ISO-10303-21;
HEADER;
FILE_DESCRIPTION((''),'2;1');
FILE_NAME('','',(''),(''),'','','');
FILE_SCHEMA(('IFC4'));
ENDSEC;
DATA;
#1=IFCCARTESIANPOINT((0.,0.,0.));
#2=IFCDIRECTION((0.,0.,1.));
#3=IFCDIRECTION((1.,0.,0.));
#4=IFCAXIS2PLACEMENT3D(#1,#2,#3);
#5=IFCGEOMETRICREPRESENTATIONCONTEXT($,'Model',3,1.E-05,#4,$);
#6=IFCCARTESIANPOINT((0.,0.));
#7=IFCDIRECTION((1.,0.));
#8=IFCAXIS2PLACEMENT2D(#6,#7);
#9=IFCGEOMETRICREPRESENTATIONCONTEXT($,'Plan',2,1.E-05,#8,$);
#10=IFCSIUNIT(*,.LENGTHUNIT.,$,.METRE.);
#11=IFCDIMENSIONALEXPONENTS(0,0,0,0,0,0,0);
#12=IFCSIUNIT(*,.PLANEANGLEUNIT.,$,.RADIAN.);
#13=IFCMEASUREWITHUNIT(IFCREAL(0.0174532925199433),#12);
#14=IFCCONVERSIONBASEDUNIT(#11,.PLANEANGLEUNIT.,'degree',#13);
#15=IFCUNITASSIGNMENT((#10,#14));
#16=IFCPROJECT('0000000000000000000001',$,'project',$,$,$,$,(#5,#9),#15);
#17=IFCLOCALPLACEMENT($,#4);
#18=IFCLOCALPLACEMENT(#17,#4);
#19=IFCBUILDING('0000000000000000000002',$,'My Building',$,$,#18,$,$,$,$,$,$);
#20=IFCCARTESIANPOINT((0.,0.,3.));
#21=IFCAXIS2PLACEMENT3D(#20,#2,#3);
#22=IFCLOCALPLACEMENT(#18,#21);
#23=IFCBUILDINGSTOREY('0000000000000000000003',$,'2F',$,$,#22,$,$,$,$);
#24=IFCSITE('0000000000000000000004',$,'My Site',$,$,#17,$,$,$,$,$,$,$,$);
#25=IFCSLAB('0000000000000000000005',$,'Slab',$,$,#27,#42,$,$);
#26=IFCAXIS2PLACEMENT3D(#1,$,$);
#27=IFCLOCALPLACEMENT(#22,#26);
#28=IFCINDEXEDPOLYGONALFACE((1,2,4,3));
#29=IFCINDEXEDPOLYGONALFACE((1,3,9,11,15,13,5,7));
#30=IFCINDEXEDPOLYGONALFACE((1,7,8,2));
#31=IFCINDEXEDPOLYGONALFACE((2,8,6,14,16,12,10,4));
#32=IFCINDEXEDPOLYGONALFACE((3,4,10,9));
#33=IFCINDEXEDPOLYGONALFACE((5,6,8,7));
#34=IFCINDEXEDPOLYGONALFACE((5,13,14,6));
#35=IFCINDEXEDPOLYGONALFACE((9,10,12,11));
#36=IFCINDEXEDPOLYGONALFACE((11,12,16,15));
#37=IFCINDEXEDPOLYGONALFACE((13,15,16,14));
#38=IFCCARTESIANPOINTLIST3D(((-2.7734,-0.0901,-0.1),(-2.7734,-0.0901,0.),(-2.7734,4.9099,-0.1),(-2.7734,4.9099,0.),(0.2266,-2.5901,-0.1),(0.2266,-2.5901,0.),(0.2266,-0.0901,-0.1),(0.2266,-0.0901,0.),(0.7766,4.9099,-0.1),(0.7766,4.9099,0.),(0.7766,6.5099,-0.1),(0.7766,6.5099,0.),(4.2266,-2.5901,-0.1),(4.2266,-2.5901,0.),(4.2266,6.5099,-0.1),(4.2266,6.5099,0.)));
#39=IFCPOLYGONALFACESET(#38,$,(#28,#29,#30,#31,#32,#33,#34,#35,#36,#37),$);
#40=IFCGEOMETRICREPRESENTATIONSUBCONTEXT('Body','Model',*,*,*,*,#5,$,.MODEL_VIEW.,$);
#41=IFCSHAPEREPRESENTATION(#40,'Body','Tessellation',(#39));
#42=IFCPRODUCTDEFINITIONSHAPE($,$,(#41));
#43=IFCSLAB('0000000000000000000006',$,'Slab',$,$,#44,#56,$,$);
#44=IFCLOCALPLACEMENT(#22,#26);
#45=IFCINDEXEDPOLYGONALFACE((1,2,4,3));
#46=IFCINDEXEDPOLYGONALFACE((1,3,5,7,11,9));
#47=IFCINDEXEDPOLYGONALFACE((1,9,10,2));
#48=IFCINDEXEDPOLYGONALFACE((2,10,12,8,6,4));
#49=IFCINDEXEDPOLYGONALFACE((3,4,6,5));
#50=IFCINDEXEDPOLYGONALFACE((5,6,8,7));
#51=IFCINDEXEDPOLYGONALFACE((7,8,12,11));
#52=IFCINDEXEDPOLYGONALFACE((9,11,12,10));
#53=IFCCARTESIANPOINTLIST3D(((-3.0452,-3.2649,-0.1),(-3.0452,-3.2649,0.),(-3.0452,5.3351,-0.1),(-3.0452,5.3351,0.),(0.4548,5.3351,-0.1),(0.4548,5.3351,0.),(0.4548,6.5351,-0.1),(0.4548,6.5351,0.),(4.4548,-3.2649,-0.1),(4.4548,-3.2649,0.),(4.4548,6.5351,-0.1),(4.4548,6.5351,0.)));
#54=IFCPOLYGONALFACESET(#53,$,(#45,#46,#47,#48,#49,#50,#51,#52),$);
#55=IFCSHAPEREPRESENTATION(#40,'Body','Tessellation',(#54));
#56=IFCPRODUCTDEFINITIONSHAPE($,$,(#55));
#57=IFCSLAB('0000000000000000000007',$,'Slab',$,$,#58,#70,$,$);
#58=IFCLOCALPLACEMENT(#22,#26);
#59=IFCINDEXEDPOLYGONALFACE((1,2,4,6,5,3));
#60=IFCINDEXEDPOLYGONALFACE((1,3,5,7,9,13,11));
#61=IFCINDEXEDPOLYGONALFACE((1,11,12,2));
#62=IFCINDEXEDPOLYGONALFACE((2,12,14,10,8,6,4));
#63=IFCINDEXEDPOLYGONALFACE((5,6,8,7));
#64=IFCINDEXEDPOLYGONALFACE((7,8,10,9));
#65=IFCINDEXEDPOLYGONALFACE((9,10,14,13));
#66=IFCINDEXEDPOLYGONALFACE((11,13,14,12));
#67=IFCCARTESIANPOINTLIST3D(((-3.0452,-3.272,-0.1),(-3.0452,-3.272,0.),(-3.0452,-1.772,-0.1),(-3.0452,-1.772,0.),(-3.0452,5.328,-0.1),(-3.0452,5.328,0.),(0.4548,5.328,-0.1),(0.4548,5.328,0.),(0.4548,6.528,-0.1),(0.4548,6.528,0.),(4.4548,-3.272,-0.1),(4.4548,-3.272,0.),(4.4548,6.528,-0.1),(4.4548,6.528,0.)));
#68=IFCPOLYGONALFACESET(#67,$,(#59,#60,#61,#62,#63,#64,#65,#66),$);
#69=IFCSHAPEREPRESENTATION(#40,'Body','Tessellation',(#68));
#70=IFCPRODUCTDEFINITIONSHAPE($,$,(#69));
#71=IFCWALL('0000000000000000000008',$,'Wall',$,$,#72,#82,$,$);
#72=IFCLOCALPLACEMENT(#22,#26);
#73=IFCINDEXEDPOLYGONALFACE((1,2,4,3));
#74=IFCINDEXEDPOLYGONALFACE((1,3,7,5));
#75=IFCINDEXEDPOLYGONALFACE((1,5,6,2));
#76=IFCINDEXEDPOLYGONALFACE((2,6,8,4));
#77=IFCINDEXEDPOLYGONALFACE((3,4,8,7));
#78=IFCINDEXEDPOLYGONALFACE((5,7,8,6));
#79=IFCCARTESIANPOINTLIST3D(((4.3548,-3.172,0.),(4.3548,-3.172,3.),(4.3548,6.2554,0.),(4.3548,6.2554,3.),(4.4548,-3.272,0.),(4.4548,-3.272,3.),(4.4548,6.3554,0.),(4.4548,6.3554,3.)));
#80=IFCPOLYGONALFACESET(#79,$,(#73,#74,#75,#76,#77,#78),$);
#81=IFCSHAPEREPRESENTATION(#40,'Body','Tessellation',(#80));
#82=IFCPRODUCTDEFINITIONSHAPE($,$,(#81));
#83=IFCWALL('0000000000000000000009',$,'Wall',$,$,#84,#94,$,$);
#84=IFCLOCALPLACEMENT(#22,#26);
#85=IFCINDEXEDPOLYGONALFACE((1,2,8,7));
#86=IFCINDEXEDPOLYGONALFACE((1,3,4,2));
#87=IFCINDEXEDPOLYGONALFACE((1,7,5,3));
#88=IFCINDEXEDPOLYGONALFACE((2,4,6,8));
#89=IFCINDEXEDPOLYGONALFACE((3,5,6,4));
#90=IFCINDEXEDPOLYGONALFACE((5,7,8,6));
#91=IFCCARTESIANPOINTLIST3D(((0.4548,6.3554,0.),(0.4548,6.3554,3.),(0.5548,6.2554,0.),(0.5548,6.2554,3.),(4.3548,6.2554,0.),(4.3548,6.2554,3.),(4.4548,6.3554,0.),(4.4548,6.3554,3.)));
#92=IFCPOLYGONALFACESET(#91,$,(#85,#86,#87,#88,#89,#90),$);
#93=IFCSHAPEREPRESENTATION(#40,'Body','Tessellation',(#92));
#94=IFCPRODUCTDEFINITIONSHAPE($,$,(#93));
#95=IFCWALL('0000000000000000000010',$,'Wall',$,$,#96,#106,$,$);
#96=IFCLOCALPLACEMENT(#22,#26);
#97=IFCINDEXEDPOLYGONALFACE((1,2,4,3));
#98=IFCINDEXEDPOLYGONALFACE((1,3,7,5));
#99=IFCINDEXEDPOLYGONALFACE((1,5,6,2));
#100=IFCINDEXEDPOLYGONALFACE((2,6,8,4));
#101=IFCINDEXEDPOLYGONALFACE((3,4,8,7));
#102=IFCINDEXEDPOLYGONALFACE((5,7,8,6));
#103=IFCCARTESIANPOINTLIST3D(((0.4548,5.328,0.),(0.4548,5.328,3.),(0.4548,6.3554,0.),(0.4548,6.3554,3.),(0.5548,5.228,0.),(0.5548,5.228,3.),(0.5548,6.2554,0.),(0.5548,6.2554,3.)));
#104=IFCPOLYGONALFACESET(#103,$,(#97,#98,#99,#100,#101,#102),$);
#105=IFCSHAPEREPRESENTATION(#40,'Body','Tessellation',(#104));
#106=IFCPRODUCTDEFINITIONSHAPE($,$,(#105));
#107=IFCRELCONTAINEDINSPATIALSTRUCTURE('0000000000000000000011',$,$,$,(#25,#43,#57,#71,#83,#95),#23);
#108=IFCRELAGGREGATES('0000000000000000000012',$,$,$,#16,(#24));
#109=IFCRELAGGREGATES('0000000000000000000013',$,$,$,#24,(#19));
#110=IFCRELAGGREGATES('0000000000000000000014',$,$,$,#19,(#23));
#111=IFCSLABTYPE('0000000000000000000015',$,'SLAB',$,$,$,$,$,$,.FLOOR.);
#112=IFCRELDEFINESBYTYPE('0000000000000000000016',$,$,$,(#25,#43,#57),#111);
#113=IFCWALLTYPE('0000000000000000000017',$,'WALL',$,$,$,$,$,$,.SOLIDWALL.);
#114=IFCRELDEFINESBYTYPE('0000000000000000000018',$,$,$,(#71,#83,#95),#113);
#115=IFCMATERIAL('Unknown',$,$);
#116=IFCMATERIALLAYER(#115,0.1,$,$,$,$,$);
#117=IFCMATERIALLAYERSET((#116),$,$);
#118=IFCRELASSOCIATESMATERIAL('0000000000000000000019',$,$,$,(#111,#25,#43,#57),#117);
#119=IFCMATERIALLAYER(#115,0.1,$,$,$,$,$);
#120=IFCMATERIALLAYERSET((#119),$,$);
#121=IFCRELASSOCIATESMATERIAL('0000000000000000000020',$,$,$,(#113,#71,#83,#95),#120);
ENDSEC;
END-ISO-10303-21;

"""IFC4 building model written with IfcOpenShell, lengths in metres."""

from ifc_helpers import new_model, entity, si_unit, converted_unit, frame, origin_with_axes, origin_2d_with_axis, place, context, subcontext, project, spatial, line, indexed_curve, outline, extrude, material, layer, layer_set, layer_usage, type_object, element, save


model = new_model("IFC4")

# Units and contexts
model_context = context("Model", 3, precision=1e-05, world=origin_with_axes())
plan_context = context("Plan", 2, precision=1e-05, world=origin_2d_with_axis())
body_context_1 = subcontext(model_context, "Body", "Model", "MODEL_VIEW")
ifc_project = project(units=[si_unit("LENGTHUNIT", "METRE"), converted_unit("PLANEANGLEUNIT", "degree", entity("IfcReal", 0.0174532925199433), si_unit("PLANEANGLEUNIT", "RADIAN"), dimensions=[0, 0, 0, 0, 0, 0, 0])], contexts=[model_context, plan_context])

# Site, building, storey
site_placement = place(None, origin_with_axes())
site = spatial("IfcSite", under=ifc_project, at=site_placement, Name="My Site")
building_placement = place(site_placement, origin_with_axes())
building = spatial("IfcBuilding", under=site, at=building_placement, Name="My Building")
storey_placement = place(building_placement, frame((0.0, 0.0, 3.0), z_axis=(0.0, 0.0, 1.0), x_axis=(1.0, 0.0, 0.0)))
storey = spatial("IfcBuildingStorey", under=building, at=storey_placement, Name="2F")

# Slabs
ifc_material = material(Name="Unknown")
ifc_layer_1 = layer(ifc_material, 0.1)
ifc_layer_set_1 = layer_set([ifc_layer_1])
ifc_layer_usage_1 = layer_usage(ifc_layer_set_1, "AXIS3", "POSITIVE", -0.1)
slab_type = type_object("IfcSlabType", Name="SLAB", PredefinedType="FLOOR", material=ifc_layer_set_1)
slab_1_placement = place(storey_placement, frame((4.2266, -2.5901, 0.0), z_axis=(0.0, 0.0, 1.0), x_axis=(1.0, 0.0, 0.0)))
element("IfcSlab", 1, at=slab_1_placement, inside=storey, type_object=slab_type, material=ifc_layer_usage_1, Name="Slab", context=body_context_1, shape_type="SweptSolid", body=[
    extrude(outline(indexed_curve([(0.0, 0.0), (0.0, 9.1), (-3.45, 9.1), (-3.45, 7.5), (-7.0, 7.5), (-7.0, 2.5), (-4.0, 2.5), (-4.0, 0.0), (0.0, 0.0)])), frame((0.0, 0.0, -0.1), z_axis=(0.0, 0.0, 1.0), x_axis=(1.0, 0.0, 0.0)), (0.0, 0.0, 1.0), 0.1),
])
ifc_layer_usage_2 = layer_usage(ifc_layer_set_1, "AXIS3", "POSITIVE", -0.1)
slab_2_placement = place(storey_placement, frame((4.4548, -3.2649, 0.0), z_axis=(0.0, 0.0, 1.0), x_axis=(1.0, 0.0, 0.0)))
element("IfcSlab", 2, at=slab_2_placement, inside=storey, type_object=slab_type, material=ifc_layer_usage_2, Name="Slab", context=body_context_1, shape_type="SweptSolid", body=[
    extrude(outline(indexed_curve([(0.0, 0.0), (0.0, 9.8), (-4.0, 9.8), (-4.0, 8.6), (-7.5, 8.6), (-7.5, 0.0), (0.0, 0.0)])), frame((0.0, 0.0, -0.1), z_axis=(0.0, 0.0, 1.0), x_axis=(1.0, 0.0, 0.0)), (0.0, 0.0, 1.0), 0.1),
])
ifc_layer_usage_3 = layer_usage(ifc_layer_set_1, "AXIS3", "POSITIVE", -0.1)
slab_3_placement = place(storey_placement, frame((4.4548, -3.272, 0.0), z_axis=(0.0, 0.0, 1.0), x_axis=(1.0, 0.0, 0.0)))
element("IfcSlab", 3, at=slab_3_placement, inside=storey, type_object=slab_type, material=ifc_layer_usage_3, Name="Slab", context=body_context_1, shape_type="SweptSolid", body=[
    extrude(outline(indexed_curve([(0.0, 0.0), (0.0, 9.8), (-4.0, 9.8), (-4.0, 8.6), (-7.5, 8.6), (-7.5, 1.5), (-7.5, 0.0), (0.0, 0.0)])), frame((0.0, 0.0, -0.1), z_axis=(0.0, 0.0, 1.0), x_axis=(1.0, 0.0, 0.0)), (0.0, 0.0, 1.0), 0.1),
])

# Walls
ifc_layer_2 = layer(ifc_material, 0.1)
ifc_layer_set_2 = layer_set([ifc_layer_2])
ifc_layer_usage_4 = layer_usage(ifc_layer_set_2, "AXIS2", "POSITIVE", 0.0)
wall_type_1 = type_object("IfcWallType", Name="WALL", PredefinedType="SOLIDWALL", material=ifc_layer_set_2)
wall_1_placement = place(storey_placement, frame((4.4548, -3.272, 0.0), z_axis=(0.0, 0.0, 1.0), x_axis=(0.0, 1.0, 0.0)))
element("IfcWall", 4, at=wall_1_placement, inside=storey, type_object=wall_type_1, material=ifc_layer_usage_4, Name="Wall", context=body_context_1, shape_type="SweptSolid", body=[
    extrude(outline(indexed_curve([(0.0, 0.0), (0.1, 0.1), (9.5273, 0.1), (9.6273, 0.0)], segments=[line(1, 2, 3, 4, 1)])), origin_with_axes(), (0.0, 0.0, 1.0), 3.0),
])
ifc_layer_usage_5 = layer_usage(ifc_layer_set_2, "AXIS2", "POSITIVE", 0.0)
wall_2_placement = place(storey_placement, frame((4.4548, 6.3554, 0.0), z_axis=(0.0, 0.0, 1.0), x_axis=(-1.0, 0.0, 0.0)))
element("IfcWall", 5, at=wall_2_placement, inside=storey, type_object=wall_type_1, material=ifc_layer_usage_5, Name="Wall", context=body_context_1, shape_type="SweptSolid", body=[
    extrude(outline(indexed_curve([(0.0, 0.0), (0.1, 0.1), (3.9, 0.1), (4.0, 0.0)], segments=[line(1, 2, 3, 4, 1)])), origin_with_axes(), (0.0, 0.0, 1.0), 3.0),
])
ifc_layer_usage_6 = layer_usage(ifc_layer_set_2, "AXIS2", "POSITIVE", 0.0)
wall_3_placement = place(storey_placement, frame((0.4548, 6.3554, 0.0), z_axis=(0.0, 0.0, 1.0), x_axis=(0.0, -1.0, 0.0)))
element("IfcWall", 6, at=wall_3_placement, inside=storey, type_object=wall_type_1, material=ifc_layer_usage_6, Name="Wall", context=body_context_1, shape_type="SweptSolid", body=[
    extrude(outline(indexed_curve([(0.0, 0.0), (0.1, 0.1), (1.1273, 0.1), (1.0273, 0.0)], segments=[line(1, 2, 3, 4, 1)])), origin_with_axes(), (0.0, 0.0, 1.0), 3.0),
])

save(model, "model.ifc")
